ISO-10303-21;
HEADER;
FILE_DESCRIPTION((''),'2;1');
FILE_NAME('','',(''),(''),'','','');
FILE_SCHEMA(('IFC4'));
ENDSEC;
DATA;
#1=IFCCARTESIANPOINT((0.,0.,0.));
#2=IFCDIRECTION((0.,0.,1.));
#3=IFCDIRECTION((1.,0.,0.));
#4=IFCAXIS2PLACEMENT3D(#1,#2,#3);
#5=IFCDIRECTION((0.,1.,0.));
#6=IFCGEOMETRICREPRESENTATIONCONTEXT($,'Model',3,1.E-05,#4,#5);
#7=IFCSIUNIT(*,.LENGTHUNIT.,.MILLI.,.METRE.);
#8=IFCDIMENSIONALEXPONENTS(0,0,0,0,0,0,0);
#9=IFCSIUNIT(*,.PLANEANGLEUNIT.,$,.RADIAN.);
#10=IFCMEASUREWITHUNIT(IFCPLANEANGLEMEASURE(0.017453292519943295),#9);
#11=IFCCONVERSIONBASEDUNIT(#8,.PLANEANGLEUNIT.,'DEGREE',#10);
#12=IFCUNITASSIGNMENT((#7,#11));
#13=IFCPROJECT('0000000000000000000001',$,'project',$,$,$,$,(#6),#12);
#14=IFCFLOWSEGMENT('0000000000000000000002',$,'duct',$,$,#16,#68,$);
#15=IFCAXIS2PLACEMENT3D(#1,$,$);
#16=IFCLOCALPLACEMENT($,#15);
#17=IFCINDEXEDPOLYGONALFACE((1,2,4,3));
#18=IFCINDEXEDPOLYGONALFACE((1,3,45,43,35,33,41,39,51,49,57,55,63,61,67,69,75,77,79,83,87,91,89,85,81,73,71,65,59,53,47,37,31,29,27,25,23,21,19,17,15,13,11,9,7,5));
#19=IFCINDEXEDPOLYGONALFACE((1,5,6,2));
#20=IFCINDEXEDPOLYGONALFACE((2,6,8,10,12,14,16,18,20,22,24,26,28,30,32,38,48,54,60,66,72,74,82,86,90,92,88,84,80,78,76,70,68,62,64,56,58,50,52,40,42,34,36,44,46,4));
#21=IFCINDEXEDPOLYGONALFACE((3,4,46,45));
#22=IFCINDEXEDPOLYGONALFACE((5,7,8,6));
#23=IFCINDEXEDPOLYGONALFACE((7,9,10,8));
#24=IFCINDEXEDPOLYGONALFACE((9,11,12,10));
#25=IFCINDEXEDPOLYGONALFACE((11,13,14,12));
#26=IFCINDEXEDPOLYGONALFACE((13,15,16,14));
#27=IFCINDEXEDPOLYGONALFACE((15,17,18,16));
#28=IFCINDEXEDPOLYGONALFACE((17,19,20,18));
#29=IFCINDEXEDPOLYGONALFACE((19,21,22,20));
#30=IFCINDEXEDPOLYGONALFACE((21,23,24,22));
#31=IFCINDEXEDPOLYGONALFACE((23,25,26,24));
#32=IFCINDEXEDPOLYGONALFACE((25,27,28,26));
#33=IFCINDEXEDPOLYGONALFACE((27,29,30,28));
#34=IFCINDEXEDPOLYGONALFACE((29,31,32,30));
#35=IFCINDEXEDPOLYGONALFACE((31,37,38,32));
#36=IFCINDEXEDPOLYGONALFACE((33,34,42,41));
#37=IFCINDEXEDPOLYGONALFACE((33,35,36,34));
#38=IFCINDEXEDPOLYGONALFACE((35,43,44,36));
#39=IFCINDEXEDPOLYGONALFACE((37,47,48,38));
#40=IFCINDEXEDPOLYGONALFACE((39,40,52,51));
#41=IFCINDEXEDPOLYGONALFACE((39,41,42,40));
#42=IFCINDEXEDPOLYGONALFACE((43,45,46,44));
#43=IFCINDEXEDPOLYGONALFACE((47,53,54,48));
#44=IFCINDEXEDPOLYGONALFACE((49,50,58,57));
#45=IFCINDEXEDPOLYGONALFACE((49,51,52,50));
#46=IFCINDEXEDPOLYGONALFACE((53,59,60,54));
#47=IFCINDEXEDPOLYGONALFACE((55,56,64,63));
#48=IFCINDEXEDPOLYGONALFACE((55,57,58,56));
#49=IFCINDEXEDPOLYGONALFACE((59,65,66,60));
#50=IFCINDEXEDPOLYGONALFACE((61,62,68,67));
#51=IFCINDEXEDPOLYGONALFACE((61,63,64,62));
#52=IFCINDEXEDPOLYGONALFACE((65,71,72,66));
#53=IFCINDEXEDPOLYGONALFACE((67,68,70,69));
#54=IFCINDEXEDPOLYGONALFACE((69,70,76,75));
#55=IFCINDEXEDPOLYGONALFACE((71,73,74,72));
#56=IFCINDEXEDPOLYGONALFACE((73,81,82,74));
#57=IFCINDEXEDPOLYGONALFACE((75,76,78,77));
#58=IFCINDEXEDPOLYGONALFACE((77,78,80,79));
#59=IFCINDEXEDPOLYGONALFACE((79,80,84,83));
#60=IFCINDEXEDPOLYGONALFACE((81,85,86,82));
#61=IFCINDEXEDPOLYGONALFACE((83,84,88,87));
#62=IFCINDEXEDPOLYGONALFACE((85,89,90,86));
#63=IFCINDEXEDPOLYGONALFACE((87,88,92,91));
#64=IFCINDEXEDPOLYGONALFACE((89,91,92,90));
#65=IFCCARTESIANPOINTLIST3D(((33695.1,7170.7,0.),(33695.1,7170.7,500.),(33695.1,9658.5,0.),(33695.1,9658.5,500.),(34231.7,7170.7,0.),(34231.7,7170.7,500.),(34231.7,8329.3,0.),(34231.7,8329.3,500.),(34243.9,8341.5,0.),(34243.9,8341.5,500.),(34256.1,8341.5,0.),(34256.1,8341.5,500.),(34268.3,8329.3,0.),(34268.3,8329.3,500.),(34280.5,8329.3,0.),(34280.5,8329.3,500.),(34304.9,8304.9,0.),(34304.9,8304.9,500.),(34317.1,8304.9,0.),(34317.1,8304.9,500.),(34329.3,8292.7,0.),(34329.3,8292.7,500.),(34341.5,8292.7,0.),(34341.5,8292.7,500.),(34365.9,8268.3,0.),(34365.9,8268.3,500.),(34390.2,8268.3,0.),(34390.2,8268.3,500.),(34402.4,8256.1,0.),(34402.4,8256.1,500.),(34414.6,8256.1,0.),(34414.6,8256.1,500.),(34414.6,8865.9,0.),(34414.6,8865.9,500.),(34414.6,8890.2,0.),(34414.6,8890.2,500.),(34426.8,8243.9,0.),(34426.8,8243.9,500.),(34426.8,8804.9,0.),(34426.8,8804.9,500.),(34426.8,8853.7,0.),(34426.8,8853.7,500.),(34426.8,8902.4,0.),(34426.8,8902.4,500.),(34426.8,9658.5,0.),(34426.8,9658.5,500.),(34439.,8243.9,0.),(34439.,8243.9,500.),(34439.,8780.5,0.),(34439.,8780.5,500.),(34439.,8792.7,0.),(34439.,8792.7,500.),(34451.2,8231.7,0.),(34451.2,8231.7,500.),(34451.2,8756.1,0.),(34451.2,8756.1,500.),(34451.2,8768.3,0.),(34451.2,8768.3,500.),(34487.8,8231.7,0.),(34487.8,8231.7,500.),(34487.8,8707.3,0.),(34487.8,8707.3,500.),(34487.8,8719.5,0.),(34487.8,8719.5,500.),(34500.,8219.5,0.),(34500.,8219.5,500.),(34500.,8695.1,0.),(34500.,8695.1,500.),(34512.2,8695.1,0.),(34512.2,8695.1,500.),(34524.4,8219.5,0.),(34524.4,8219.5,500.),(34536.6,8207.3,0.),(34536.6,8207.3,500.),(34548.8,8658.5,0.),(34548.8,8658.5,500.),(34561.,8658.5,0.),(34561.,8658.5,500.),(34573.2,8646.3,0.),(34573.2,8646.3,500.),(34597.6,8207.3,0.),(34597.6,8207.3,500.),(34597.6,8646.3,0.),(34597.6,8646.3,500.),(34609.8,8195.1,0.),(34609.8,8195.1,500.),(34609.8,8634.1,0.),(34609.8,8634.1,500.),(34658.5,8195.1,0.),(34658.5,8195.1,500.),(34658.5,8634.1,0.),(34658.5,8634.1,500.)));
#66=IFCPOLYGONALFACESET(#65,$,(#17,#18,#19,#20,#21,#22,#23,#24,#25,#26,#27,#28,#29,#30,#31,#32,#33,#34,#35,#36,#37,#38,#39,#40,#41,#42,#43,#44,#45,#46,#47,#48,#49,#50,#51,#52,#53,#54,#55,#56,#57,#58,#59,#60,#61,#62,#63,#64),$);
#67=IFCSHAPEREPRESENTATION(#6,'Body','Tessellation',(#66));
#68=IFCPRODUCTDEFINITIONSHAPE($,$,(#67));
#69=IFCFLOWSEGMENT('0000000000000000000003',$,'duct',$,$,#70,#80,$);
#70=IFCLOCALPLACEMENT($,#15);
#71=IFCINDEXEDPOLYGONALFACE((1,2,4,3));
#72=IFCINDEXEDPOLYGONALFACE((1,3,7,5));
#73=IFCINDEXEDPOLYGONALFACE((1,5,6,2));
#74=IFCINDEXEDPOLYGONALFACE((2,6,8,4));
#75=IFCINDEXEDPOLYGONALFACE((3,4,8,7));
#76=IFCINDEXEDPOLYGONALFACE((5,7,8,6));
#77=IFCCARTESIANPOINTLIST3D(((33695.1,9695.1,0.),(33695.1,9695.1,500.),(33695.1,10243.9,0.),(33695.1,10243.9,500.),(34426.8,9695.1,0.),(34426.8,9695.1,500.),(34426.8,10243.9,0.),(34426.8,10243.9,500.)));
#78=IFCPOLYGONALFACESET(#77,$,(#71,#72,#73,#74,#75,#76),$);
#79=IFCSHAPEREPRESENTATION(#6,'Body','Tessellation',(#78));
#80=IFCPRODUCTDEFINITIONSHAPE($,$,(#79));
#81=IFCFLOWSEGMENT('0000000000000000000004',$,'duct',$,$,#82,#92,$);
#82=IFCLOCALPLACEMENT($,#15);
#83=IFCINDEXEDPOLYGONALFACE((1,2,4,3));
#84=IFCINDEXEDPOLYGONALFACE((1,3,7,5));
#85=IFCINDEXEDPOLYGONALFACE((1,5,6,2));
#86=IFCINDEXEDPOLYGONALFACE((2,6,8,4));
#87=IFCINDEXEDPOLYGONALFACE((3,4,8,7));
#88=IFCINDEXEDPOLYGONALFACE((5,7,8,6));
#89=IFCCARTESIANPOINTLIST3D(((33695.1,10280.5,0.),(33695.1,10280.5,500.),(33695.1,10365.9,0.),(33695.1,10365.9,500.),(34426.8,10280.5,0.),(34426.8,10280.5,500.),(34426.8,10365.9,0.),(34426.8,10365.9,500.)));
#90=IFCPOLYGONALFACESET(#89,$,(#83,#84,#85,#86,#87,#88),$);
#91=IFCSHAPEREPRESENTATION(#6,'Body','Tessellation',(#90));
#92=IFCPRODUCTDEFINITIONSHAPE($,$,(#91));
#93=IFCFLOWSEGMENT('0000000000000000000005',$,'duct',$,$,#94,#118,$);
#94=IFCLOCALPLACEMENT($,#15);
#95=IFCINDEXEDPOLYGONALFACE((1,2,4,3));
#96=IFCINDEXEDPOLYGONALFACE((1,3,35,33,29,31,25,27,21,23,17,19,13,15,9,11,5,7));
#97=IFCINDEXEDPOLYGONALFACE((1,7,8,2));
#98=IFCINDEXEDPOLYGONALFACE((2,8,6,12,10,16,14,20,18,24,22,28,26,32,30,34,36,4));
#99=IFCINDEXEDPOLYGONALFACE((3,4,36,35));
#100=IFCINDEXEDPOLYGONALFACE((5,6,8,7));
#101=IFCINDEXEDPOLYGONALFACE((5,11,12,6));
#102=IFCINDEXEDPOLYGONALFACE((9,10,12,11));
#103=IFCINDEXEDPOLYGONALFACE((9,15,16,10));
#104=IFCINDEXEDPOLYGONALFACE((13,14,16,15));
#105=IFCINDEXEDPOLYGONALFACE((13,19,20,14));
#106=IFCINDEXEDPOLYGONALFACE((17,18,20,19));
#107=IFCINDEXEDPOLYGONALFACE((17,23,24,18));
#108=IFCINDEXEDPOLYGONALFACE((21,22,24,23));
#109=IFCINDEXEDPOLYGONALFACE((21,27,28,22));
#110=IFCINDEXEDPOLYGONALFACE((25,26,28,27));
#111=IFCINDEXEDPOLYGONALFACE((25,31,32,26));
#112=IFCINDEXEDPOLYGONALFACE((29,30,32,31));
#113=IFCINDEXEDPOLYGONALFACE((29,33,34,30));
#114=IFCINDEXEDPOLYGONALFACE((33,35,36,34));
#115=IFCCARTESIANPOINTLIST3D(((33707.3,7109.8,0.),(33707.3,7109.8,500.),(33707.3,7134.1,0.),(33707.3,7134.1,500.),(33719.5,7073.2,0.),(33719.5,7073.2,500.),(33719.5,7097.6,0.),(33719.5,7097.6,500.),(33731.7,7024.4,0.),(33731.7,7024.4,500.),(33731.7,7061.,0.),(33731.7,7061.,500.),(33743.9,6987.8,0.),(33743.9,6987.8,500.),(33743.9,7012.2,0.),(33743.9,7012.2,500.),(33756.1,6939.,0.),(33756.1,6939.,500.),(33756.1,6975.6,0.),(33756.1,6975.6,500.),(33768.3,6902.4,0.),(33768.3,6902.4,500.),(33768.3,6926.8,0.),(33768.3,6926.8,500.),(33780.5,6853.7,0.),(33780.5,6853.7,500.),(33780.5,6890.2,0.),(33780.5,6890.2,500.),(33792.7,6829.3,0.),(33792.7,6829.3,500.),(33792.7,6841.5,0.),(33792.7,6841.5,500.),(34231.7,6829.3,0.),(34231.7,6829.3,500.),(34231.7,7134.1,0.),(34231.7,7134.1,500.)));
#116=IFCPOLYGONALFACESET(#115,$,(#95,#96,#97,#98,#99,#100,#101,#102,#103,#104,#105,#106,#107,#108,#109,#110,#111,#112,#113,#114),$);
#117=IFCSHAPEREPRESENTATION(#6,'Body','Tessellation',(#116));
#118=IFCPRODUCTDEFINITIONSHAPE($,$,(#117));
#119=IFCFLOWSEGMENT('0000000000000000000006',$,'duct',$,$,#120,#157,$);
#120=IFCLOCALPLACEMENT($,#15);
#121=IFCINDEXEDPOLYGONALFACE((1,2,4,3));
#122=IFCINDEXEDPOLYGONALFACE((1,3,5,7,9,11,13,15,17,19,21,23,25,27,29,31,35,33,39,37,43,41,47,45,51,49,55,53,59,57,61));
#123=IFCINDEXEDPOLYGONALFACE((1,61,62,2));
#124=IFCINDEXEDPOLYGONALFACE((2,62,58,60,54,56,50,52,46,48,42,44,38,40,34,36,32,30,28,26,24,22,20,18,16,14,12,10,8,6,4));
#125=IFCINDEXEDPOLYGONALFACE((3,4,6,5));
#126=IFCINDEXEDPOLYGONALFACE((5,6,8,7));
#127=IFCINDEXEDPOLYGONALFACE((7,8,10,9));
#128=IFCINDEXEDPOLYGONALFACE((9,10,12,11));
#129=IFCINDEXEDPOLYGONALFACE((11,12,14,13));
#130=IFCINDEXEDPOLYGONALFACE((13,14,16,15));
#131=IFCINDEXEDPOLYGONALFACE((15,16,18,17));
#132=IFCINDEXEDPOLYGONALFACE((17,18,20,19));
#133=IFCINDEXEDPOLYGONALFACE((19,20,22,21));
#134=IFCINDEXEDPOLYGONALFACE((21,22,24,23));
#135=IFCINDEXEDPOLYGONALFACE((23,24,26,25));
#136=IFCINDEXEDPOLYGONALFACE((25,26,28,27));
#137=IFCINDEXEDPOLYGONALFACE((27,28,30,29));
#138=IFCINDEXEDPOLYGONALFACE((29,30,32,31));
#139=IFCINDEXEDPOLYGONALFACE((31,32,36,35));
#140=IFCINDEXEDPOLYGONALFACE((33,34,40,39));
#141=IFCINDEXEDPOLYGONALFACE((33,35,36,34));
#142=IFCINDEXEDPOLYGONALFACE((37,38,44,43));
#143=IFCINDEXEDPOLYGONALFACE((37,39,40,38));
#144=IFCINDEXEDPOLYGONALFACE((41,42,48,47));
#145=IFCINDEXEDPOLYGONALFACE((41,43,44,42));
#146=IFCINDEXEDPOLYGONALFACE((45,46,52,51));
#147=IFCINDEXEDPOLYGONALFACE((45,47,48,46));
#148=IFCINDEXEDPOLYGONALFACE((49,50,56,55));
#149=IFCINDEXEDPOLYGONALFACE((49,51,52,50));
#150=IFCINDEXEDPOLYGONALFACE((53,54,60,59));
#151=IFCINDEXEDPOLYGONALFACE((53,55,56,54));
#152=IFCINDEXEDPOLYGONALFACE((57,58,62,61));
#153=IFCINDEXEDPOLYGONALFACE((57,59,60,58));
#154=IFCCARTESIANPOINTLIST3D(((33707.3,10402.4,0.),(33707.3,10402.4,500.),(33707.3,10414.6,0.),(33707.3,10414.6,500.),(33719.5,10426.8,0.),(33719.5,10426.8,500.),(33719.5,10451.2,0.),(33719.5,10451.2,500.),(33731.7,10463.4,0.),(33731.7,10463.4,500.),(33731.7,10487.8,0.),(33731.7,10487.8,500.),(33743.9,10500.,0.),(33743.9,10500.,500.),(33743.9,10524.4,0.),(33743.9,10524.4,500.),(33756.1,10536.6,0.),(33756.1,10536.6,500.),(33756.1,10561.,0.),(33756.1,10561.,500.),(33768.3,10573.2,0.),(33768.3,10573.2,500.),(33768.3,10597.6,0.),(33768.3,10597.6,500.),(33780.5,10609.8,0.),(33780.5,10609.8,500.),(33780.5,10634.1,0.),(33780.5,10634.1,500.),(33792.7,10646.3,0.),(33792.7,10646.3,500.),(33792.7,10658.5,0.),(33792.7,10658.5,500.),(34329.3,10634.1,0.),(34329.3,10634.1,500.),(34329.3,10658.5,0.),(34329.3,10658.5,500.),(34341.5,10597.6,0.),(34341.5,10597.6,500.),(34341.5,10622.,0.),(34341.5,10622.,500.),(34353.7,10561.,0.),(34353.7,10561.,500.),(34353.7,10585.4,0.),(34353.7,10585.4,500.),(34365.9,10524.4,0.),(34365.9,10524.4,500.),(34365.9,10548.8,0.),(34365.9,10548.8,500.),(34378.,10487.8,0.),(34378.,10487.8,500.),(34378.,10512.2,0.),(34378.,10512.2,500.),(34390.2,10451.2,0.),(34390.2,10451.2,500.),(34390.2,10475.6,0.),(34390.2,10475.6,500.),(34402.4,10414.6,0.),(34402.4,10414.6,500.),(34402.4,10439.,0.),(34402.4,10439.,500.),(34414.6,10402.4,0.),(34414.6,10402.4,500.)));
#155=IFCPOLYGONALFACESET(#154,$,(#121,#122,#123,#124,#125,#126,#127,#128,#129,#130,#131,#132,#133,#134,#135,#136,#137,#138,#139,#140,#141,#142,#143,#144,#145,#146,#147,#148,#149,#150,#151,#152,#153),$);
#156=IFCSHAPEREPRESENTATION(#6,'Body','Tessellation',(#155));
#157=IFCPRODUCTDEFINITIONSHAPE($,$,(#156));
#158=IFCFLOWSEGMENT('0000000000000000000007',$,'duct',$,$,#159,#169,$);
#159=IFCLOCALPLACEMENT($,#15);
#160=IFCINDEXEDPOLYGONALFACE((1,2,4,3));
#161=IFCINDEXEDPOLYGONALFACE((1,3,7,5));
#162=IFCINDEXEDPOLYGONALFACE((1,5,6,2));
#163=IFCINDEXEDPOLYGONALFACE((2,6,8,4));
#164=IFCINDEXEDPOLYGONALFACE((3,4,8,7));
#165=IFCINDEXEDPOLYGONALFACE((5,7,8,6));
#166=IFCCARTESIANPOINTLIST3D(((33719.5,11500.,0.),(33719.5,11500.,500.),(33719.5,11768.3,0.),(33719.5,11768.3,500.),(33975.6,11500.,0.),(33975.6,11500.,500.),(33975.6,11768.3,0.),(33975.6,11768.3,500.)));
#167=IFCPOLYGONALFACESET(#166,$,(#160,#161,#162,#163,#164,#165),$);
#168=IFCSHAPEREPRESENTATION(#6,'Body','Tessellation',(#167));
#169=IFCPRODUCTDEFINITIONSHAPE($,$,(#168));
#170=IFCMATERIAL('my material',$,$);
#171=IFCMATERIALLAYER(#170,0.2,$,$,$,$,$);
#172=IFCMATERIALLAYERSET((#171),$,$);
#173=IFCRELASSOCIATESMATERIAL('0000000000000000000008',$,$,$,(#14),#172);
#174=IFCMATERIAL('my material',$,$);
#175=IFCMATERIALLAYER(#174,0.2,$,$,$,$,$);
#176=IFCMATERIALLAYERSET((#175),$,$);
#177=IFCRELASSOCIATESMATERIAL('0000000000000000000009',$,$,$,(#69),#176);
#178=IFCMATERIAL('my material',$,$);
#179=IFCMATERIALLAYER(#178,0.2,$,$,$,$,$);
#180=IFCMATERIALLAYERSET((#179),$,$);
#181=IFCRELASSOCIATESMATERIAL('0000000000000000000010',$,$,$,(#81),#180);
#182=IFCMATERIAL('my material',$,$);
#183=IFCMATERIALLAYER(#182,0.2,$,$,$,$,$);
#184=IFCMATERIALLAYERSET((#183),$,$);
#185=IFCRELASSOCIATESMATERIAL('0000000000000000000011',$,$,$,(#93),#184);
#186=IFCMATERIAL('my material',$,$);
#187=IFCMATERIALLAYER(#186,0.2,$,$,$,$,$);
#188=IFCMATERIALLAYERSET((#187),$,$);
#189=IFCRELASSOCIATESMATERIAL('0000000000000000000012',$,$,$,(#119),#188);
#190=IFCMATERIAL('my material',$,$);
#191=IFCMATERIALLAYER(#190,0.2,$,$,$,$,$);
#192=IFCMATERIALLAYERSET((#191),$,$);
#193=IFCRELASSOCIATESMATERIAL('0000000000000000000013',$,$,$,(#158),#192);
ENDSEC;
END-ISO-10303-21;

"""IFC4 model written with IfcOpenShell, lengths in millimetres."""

from ifc_helpers import new_model, entity, si_unit, converted_unit, direction, origin_with_axes, place, context, project, polyline, outline, extrude, material, layer, layer_set, layer_usage, element, save


model = new_model("IFC4")

# Units and contexts
model_context = context("Model", 3, precision=1e-05, world=origin_with_axes(), true_north=direction((0.0, 1.0, 0.0)))
ifc_project = project(units=[si_unit("LENGTHUNIT", "METRE", prefix="MILLI"), converted_unit("PLANEANGLEUNIT", "DEGREE", entity("IfcPlaneAngleMeasure", 0.017453292519943295), si_unit("PLANEANGLEUNIT", "RADIAN"), dimensions=[0, 0, 0, 0, 0, 0, 0])], contexts=[model_context])

# Flow segments
ifc_material_1 = material(Name="my material")
ifc_layer_1 = layer(ifc_material_1, 0.2)
ifc_layer_set_1 = layer_set([ifc_layer_1])
ifc_layer_usage_1 = layer_usage(ifc_layer_set_1, "AXIS2", "POSITIVE", -0.1)
flow_segment_1_placement = place(None, origin_with_axes())
element("IfcFlowSegment", 1, at=flow_segment_1_placement, material=ifc_layer_usage_1, Name="duct", context=model_context, shape_type="SweptSolid", body=[
    extrude(outline(polyline([(33695.1, 7170.7), (34231.7, 7170.7), (34231.7, 8329.3), (34243.9, 8341.5), (34256.1, 8341.5), (34268.3, 8329.3), (34280.5, 8329.3), (34304.9, 8304.9), (34317.1, 8304.9), (34329.3, 8292.7), (34341.5, 8292.7), (34365.9, 8268.3), (34390.2, 8268.3), (34402.4, 8256.1), (34414.6, 8256.1), (34426.8, 8243.9), (34439.0, 8243.9), (34451.2, 8231.7), (34487.8, 8231.7), (34500.0, 8219.5), (34524.4, 8219.5), (34536.6, 8207.3), (34597.6, 8207.3), (34609.8, 8195.1), (34658.5, 8195.1), (34658.5, 8634.1), (34609.8, 8634.1), (34597.6, 8646.3), (34573.2, 8646.3), (34561.0, 8658.5), (34548.8, 8658.5), (34512.2, 8695.1), (34500.0, 8695.1), (34487.8, 8707.3), (34487.8, 8719.5), (34451.2, 8756.1), (34451.2, 8768.3), (34439.0, 8780.5), (34439.0, 8792.7), (34426.8, 8804.9), (34426.8, 8853.7), (34414.6, 8865.9), (34414.6, 8890.2), (34426.8, 8902.4), (34426.8, 9658.5), (33695.1, 9658.5), (33695.1, 7170.7)])), origin_with_axes(), (0.0, 0.0, 1.0), 500.0),
])
ifc_material_2 = material(Name="my material")
ifc_layer_2 = layer(ifc_material_2, 0.2)
ifc_layer_set_2 = layer_set([ifc_layer_2])
ifc_layer_usage_2 = layer_usage(ifc_layer_set_2, "AXIS2", "POSITIVE", -0.1)
flow_segment_2_placement = place(None, origin_with_axes())
element("IfcFlowSegment", 2, at=flow_segment_2_placement, material=ifc_layer_usage_2, Name="duct", context=model_context, shape_type="SweptSolid", body=[
    extrude(outline(polyline([(33695.1, 9695.1), (34426.8, 9695.1), (34426.8, 10243.9), (33695.1, 10243.9), (33695.1, 9695.1)])), origin_with_axes(), (0.0, 0.0, 1.0), 500.0),
])
ifc_material_3 = material(Name="my material")
ifc_layer_3 = layer(ifc_material_3, 0.2)
ifc_layer_set_3 = layer_set([ifc_layer_3])
ifc_layer_usage_3 = layer_usage(ifc_layer_set_3, "AXIS2", "POSITIVE", -0.1)
flow_segment_3_placement = place(None, origin_with_axes())
element("IfcFlowSegment", 3, at=flow_segment_3_placement, material=ifc_layer_usage_3, Name="duct", context=model_context, shape_type="SweptSolid", body=[
    extrude(outline(polyline([(33695.1, 10280.5), (34426.8, 10280.5), (34426.8, 10365.9), (33695.1, 10365.9), (33695.1, 10280.5)])), origin_with_axes(), (0.0, 0.0, 1.0), 500.0),
])
ifc_material_4 = material(Name="my material")
ifc_layer_4 = layer(ifc_material_4, 0.2)
ifc_layer_set_4 = layer_set([ifc_layer_4])
ifc_layer_usage_4 = layer_usage(ifc_layer_set_4, "AXIS2", "POSITIVE", -0.1)
flow_segment_4_placement = place(None, origin_with_axes())
element("IfcFlowSegment", 4, at=flow_segment_4_placement, material=ifc_layer_usage_4, Name="duct", context=model_context, shape_type="SweptSolid", body=[
    extrude(outline(polyline([(33707.3, 7109.8), (33719.5, 7097.6), (33719.5, 7073.2), (33731.7, 7061.0), (33731.7, 7024.4), (33743.9, 7012.2), (33743.9, 6987.8), (33756.1, 6975.6), (33756.1, 6939.0), (33768.3, 6926.8), (33768.3, 6902.4), (33780.5, 6890.2), (33780.5, 6853.7), (33792.7, 6841.5), (33792.7, 6829.3), (34231.7, 6829.3), (34231.7, 7134.1), (33707.3, 7134.1), (33707.3, 7109.8)])), origin_with_axes(), (0.0, 0.0, 1.0), 500.0),
])
ifc_material_5 = material(Name="my material")
ifc_layer_5 = layer(ifc_material_5, 0.2)
ifc_layer_set_5 = layer_set([ifc_layer_5])
ifc_layer_usage_5 = layer_usage(ifc_layer_set_5, "AXIS2", "POSITIVE", -0.1)
flow_segment_5_placement = place(None, origin_with_axes())
element("IfcFlowSegment", 5, at=flow_segment_5_placement, material=ifc_layer_usage_5, Name="duct", context=model_context, shape_type="SweptSolid", body=[
    extrude(outline(polyline([(33707.3, 10402.4), (34414.6, 10402.4), (34402.4, 10414.6), (34402.4, 10439.0), (34390.2, 10451.2), (34390.2, 10475.6), (34378.0, 10487.8), (34378.0, 10512.2), (34365.9, 10524.4), (34365.9, 10548.8), (34353.7, 10561.0), (34353.7, 10585.4), (34341.5, 10597.6), (34341.5, 10622.0), (34329.3, 10634.1), (34329.3, 10658.5), (33792.7, 10658.5), (33792.7, 10646.3), (33780.5, 10634.1), (33780.5, 10609.8), (33768.3, 10597.6), (33768.3, 10573.2), (33756.1, 10561.0), (33756.1, 10536.6), (33743.9, 10524.4), (33743.9, 10500.0), (33731.7, 10487.8), (33731.7, 10463.4), (33719.5, 10451.2), (33719.5, 10426.8), (33707.3, 10414.6), (33707.3, 10402.4)])), origin_with_axes(), (0.0, 0.0, 1.0), 500.0),
])
ifc_material_6 = material(Name="my material")
ifc_layer_6 = layer(ifc_material_6, 0.2)
ifc_layer_set_6 = layer_set([ifc_layer_6])
ifc_layer_usage_6 = layer_usage(ifc_layer_set_6, "AXIS2", "POSITIVE", -0.1)
flow_segment_6_placement = place(None, origin_with_axes())
element("IfcFlowSegment", 6, at=flow_segment_6_placement, material=ifc_layer_usage_6, Name="duct", context=model_context, shape_type="SweptSolid", body=[
    extrude(outline(polyline([(33719.5, 11500.0), (33975.6, 11500.0), (33975.6, 11768.3), (33719.5, 11768.3), (33719.5, 11500.0)])), origin_with_axes(), (0.0, 0.0, 1.0), 500.0),
])

save(model, "model.ifc")
